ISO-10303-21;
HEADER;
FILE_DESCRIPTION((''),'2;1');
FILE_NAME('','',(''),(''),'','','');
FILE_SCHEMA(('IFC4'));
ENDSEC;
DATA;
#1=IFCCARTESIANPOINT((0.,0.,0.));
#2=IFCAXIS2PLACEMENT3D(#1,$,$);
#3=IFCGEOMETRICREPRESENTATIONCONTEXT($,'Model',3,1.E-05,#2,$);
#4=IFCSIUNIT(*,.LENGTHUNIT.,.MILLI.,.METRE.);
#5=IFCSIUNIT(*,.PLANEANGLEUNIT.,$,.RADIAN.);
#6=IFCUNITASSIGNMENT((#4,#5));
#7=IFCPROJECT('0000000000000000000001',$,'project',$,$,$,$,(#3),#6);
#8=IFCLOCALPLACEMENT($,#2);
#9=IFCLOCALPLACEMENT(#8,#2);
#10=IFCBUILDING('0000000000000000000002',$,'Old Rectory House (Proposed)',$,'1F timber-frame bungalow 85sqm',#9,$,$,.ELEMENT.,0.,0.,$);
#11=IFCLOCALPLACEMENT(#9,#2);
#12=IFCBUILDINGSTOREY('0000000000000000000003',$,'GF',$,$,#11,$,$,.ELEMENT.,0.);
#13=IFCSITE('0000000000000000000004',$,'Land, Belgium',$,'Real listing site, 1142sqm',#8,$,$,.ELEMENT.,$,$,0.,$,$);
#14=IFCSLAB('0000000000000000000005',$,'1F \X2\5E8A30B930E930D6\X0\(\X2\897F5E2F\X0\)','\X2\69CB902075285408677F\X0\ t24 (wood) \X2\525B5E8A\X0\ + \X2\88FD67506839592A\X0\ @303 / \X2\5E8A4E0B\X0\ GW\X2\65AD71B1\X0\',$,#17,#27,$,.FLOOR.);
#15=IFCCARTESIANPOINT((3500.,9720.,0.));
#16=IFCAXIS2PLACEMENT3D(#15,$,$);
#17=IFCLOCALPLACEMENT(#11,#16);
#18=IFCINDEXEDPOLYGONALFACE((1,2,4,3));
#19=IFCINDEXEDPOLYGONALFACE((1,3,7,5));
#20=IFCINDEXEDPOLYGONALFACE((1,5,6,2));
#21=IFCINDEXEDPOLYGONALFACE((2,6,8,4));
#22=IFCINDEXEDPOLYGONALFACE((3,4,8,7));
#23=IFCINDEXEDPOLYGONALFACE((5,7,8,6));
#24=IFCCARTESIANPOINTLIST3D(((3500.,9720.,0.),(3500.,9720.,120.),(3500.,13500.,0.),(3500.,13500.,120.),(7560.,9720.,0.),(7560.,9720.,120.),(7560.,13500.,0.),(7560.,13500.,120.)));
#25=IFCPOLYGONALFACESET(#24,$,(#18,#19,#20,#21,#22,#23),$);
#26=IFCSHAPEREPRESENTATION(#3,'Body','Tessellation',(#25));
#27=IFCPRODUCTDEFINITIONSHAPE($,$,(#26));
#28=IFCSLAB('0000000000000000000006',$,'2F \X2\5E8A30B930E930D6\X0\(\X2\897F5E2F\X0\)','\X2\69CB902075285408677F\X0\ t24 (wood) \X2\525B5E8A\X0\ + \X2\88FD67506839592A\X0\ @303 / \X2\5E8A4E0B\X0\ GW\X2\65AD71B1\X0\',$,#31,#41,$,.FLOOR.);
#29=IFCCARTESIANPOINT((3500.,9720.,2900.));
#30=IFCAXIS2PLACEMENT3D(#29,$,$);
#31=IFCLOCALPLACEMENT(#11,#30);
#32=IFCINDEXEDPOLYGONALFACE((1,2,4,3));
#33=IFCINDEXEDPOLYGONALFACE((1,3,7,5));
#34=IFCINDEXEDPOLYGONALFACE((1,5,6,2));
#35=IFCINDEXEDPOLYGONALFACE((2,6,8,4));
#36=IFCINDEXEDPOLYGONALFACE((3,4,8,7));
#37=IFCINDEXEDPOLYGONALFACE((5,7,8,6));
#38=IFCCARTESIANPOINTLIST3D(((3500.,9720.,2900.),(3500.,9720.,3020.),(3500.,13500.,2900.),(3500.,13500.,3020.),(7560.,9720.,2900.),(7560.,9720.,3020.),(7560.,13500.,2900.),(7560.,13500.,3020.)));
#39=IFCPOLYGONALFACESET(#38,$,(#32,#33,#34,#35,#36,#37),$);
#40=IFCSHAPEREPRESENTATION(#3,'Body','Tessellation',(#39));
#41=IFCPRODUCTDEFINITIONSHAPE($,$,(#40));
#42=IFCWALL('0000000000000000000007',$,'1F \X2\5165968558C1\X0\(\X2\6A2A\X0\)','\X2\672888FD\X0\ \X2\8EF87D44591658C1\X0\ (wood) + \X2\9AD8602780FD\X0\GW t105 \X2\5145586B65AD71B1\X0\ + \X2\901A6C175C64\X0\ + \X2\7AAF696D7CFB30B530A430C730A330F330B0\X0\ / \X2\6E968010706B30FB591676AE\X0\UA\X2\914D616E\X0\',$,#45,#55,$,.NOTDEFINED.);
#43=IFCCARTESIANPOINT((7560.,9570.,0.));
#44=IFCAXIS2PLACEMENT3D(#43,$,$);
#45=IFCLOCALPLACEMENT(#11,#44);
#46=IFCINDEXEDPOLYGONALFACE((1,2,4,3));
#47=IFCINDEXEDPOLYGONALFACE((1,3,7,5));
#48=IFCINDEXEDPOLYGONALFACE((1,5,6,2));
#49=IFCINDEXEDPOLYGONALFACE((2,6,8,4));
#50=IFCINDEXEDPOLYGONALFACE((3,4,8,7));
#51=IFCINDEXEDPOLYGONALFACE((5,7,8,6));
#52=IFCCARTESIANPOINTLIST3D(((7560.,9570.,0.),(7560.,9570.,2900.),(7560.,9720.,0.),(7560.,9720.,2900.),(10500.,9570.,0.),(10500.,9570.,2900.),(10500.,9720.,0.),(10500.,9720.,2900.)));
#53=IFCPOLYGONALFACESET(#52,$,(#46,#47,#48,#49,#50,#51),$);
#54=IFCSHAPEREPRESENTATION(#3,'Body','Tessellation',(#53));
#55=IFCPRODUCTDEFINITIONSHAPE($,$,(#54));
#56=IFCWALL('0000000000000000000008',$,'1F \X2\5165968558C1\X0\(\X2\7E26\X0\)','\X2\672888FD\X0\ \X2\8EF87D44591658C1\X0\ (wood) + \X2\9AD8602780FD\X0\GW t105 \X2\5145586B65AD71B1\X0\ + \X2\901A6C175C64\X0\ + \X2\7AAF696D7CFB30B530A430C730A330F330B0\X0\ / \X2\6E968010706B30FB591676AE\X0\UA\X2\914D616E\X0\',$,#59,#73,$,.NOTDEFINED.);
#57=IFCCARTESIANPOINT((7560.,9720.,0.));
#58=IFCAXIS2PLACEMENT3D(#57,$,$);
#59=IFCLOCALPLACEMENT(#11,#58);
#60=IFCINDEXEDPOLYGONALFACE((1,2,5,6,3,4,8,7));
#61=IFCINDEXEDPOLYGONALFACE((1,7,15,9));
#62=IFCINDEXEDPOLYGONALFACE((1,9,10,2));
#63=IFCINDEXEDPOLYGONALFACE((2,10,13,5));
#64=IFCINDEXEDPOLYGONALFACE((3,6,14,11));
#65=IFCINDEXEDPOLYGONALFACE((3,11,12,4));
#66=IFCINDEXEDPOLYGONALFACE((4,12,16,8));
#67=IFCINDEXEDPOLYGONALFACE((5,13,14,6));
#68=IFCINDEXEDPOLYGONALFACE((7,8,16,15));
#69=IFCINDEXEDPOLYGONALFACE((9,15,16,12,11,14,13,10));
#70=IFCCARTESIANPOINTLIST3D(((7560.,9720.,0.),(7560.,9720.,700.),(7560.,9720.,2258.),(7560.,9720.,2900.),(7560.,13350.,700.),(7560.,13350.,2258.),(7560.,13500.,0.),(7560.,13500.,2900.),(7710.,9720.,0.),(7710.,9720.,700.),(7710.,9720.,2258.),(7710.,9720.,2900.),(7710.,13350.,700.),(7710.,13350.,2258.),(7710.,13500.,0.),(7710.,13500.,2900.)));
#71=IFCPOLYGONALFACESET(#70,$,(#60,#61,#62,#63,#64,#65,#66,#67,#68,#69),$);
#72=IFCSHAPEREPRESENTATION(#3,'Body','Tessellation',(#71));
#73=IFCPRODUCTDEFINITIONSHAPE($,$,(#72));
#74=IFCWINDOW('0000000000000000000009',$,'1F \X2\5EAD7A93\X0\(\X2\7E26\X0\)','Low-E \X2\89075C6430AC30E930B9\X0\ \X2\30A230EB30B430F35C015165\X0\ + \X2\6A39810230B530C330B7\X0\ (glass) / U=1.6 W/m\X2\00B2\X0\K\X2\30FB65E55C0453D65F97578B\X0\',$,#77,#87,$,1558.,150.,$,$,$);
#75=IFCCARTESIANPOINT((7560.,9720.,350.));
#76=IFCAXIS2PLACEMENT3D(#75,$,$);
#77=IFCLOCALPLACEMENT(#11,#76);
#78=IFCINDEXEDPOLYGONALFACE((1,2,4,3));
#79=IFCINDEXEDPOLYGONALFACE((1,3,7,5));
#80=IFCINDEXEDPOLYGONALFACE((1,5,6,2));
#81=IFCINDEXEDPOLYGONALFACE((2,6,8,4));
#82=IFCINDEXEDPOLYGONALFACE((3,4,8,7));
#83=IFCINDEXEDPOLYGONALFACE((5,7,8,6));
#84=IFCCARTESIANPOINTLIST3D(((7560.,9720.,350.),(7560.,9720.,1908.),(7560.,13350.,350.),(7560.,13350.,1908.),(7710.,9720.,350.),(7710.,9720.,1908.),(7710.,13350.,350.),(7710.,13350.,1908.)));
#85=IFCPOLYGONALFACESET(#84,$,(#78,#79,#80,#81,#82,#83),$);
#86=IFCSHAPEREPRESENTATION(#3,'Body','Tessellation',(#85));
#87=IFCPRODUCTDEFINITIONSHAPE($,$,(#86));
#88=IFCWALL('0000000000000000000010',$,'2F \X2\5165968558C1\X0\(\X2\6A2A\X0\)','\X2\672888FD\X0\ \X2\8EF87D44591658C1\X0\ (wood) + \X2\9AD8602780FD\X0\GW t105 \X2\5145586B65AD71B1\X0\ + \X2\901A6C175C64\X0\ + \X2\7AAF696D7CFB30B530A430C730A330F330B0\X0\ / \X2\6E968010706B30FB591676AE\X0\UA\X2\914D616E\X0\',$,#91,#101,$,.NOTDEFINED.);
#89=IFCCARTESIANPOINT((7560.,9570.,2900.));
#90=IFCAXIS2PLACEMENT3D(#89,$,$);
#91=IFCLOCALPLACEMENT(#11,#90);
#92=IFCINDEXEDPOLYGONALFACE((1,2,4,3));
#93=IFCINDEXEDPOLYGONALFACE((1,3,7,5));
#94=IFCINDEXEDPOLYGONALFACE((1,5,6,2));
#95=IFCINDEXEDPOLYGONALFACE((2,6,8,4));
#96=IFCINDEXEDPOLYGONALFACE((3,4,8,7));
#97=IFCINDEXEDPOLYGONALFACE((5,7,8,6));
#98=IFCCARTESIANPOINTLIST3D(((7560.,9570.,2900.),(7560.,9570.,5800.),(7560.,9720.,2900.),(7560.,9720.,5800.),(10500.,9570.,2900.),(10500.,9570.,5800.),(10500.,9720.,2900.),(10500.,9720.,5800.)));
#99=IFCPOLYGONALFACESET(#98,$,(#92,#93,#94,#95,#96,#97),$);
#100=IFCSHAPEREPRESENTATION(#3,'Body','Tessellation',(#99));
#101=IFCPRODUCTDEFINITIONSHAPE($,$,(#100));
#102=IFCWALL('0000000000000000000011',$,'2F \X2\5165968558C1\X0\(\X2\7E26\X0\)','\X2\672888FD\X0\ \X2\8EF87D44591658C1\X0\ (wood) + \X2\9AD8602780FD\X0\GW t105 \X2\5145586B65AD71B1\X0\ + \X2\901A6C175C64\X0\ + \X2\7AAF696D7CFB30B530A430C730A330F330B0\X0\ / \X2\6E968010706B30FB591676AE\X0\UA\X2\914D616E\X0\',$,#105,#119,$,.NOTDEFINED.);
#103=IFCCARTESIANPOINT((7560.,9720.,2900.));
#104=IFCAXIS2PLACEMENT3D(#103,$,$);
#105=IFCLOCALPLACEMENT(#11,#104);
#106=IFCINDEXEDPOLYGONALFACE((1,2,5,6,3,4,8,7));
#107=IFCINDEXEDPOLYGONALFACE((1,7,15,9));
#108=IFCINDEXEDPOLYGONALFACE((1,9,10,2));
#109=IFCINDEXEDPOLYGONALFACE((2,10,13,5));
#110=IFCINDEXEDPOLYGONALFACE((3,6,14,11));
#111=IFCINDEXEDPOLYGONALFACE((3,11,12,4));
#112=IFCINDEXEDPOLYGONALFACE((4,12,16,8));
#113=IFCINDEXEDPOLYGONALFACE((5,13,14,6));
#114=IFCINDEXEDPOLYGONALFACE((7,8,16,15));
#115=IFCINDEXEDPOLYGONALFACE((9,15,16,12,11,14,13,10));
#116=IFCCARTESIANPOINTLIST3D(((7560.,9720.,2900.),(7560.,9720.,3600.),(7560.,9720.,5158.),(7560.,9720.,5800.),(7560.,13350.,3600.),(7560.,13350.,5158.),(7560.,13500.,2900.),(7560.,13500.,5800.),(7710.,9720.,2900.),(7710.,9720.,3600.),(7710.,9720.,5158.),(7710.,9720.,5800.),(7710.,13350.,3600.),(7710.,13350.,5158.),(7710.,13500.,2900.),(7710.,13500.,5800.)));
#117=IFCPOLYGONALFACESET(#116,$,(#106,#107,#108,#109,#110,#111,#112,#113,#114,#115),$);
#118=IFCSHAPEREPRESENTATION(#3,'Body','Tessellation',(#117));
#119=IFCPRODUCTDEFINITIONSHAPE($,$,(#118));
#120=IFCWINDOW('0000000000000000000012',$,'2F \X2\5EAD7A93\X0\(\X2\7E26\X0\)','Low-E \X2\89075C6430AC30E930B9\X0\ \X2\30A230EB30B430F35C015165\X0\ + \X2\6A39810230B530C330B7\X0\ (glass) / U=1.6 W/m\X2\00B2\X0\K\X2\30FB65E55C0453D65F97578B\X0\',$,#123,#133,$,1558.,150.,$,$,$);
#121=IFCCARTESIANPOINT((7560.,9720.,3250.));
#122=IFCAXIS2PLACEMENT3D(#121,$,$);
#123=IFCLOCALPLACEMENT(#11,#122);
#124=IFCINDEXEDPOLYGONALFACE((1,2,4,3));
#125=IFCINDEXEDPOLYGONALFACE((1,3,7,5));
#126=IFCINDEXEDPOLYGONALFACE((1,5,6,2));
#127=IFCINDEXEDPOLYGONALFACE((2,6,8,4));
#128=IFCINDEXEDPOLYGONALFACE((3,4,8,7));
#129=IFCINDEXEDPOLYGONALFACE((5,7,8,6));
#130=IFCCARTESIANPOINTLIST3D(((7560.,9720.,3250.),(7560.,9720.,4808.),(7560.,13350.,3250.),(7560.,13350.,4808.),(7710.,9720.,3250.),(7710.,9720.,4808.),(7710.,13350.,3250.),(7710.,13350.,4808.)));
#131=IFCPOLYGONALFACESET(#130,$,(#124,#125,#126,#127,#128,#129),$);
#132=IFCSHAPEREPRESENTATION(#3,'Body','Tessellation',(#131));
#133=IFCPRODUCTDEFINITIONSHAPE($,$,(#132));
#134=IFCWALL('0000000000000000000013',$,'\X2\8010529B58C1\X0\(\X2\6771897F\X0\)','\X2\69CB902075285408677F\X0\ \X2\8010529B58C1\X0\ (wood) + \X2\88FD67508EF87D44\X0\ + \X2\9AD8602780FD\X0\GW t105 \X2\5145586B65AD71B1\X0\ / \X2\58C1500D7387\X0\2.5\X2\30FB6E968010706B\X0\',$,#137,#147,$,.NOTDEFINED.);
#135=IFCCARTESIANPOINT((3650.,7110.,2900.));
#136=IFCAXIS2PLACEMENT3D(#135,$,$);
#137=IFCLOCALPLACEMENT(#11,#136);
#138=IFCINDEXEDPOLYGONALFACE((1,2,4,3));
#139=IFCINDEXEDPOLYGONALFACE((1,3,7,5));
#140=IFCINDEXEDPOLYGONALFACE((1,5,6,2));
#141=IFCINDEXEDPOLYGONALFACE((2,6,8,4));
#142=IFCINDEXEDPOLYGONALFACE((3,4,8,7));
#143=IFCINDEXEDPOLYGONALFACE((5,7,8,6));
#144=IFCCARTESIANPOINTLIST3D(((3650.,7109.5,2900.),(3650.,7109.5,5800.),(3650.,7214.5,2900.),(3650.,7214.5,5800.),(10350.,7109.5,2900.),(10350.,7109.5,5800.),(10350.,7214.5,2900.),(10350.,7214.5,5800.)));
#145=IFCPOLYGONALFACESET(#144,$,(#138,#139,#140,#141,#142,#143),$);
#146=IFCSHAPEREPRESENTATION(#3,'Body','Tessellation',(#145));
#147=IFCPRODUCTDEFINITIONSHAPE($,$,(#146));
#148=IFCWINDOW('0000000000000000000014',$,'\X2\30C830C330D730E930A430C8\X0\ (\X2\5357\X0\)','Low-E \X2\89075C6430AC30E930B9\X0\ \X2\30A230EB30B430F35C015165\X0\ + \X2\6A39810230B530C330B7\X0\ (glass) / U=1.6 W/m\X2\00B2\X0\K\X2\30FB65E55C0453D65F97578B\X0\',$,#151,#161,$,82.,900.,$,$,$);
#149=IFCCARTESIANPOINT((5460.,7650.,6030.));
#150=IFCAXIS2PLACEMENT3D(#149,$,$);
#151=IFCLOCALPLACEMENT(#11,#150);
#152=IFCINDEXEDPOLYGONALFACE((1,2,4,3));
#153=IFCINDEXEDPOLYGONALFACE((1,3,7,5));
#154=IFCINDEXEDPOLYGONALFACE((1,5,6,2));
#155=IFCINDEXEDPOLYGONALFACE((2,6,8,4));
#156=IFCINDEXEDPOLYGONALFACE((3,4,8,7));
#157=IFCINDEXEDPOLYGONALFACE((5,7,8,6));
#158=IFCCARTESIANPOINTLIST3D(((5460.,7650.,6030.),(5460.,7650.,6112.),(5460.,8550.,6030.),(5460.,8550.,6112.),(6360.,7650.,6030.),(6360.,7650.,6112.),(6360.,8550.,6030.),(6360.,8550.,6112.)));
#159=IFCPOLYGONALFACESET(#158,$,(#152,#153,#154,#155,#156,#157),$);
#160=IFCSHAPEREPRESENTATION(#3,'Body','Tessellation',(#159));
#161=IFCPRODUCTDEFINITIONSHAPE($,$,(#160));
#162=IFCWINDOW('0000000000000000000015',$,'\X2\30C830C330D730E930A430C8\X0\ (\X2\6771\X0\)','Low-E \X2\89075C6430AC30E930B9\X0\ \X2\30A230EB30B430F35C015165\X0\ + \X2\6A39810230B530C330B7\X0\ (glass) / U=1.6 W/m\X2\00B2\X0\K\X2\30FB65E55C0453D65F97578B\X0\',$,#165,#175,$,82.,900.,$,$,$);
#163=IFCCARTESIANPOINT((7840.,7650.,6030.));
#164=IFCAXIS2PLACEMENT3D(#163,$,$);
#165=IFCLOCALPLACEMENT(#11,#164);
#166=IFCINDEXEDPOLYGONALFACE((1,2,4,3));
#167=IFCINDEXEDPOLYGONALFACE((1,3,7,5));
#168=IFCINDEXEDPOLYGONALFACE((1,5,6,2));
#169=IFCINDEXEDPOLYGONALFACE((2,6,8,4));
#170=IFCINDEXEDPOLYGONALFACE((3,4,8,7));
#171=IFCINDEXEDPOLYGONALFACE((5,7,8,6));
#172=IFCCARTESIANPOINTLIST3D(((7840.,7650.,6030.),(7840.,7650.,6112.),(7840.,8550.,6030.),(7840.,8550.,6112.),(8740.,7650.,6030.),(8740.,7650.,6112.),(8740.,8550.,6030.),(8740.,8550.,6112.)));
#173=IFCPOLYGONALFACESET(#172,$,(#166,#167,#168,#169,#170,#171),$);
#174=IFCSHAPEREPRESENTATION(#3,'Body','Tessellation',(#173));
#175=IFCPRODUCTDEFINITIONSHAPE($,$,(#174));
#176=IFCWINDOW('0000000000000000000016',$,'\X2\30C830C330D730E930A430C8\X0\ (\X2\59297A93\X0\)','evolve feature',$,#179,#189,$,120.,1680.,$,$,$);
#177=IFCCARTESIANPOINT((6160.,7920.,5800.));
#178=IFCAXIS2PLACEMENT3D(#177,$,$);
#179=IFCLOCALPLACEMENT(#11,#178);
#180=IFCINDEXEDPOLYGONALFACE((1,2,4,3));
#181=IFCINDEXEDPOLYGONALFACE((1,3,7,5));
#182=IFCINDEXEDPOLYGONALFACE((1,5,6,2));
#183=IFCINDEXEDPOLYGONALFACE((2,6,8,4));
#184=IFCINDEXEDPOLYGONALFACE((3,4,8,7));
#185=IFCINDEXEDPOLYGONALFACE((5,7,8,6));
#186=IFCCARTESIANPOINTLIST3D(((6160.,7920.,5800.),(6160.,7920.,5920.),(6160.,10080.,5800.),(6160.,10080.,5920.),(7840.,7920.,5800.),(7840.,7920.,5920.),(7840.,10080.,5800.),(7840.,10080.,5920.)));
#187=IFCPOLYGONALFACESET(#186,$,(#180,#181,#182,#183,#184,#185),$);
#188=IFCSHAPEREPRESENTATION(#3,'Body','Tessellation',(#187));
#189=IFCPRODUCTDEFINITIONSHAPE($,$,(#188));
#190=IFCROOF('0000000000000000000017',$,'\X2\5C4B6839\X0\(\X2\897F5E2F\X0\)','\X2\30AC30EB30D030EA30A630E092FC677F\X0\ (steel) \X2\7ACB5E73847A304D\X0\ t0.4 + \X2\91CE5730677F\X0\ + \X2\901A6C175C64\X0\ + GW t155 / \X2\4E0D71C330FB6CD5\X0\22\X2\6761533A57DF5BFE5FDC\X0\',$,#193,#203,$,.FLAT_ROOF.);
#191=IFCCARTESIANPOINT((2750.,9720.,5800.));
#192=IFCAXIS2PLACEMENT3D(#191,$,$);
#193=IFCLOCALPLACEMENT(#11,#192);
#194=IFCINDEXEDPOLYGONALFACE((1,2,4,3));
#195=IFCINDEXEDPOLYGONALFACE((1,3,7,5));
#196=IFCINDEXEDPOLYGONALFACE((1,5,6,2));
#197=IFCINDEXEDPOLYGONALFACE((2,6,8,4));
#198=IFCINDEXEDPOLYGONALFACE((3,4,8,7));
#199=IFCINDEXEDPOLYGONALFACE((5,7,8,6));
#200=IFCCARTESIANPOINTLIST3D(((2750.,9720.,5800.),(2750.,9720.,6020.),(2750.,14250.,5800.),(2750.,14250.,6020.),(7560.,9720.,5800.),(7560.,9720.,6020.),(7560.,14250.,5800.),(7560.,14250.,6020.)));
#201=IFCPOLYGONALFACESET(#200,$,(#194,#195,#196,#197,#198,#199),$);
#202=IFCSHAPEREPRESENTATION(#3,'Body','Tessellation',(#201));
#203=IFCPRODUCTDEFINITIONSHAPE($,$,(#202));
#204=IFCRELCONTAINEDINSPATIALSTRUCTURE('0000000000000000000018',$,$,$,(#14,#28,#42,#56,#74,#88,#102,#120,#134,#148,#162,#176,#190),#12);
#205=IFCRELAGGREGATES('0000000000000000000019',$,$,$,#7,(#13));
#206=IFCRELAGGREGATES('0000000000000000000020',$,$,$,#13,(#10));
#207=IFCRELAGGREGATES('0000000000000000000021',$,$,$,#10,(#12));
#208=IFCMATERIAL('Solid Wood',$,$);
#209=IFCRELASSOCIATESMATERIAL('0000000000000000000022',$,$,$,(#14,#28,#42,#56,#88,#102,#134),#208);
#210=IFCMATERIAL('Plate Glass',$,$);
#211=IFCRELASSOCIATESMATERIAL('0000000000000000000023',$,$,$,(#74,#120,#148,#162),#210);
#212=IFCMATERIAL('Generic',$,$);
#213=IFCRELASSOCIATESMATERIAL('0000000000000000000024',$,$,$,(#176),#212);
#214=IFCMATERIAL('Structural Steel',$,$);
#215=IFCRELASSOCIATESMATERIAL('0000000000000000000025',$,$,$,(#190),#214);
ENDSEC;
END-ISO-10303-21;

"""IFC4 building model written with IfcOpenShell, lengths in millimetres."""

from ifc_helpers import new_model, si_unit, frame, frame_2d, origin, place, context, project, spatial, rectangle, extrude, material, element, fill, save


model = new_model("IFC4")

# Units and contexts
model_context = context("Model", 3, precision=1e-05, world=origin())
ifc_project = project(units=[si_unit("LENGTHUNIT", "METRE", prefix="MILLI"), si_unit("PLANEANGLEUNIT", "RADIAN")], contexts=[model_context])

# Site, building, storey
site_placement = place(None, origin())
site = spatial("IfcSite", under=ifc_project, at=site_placement, Name="Land, Belgium", ObjectType="Real listing site, 1142sqm", CompositionType="ELEMENT", RefElevation=0.0)
building_placement = place(site_placement, origin())
building = spatial("IfcBuilding", under=site, at=building_placement, Name="Old Rectory House (Proposed)", ObjectType="1F timber-frame bungalow 85sqm", CompositionType="ELEMENT", ElevationOfRefHeight=0.0, ElevationOfTerrain=0.0)
storey_placement = place(building_placement, origin())
storey = spatial("IfcBuildingStorey", under=building, at=storey_placement, Name="GF", CompositionType="ELEMENT", Elevation=0.0)

# Slabs
ifc_material_1 = material(Name="Solid Wood")
slab_1_placement = place(storey_placement, frame((3500.0, 9720.0, 0.0)))
element("IfcSlab", 1, at=slab_1_placement, inside=storey, material=ifc_material_1, Name="1F 床スラブ(西帯)", Description="構造用合板 t24 (wood) 剛床 + 製材根太 @303 / 床下 GW断熱", PredefinedType="FLOOR", context=model_context, shape_type="SweptSolid", body=[
    extrude(rectangle(XDim=4060.0, YDim=3780.0, at=frame_2d((2030.0, 1890.0))), frame((3500.0, 9720.0, 0.0)), (0.0, 0.0, 1.0), 120.0),
])
slab_2_placement = place(storey_placement, frame((3500.0, 9720.0, 2900.0)))
element("IfcSlab", 2, at=slab_2_placement, inside=storey, material=ifc_material_1, Name="2F 床スラブ(西帯)", Description="構造用合板 t24 (wood) 剛床 + 製材根太 @303 / 床下 GW断熱", PredefinedType="FLOOR", context=model_context, shape_type="SweptSolid", body=[
    extrude(rectangle(XDim=4060.0, YDim=3780.0, at=frame_2d((2030.0, 1890.0))), frame((3500.0, 9720.0, 2900.0)), (0.0, 0.0, 1.0), 120.0),
])

# Wall
wall_1_placement = place(storey_placement, frame((7560.0, 9570.0, 0.0)))
element("IfcWall", 3, at=wall_1_placement, inside=storey, material=ifc_material_1, Name="1F 入隅壁(横)", Description="木製 軸組外壁 (wood) + 高性能GW t105 充填断熱 + 通気層 + 窯業系サイディング / 準耐火・外皮UA配慮", PredefinedType="NOTDEFINED", context=model_context, shape_type="SweptSolid", body=[
    extrude(rectangle(XDim=2940.0, YDim=150.0, at=frame_2d((1470.0, 75.0))), frame((7560.0, 9570.0, 0.0)), (0.0, 0.0, 1.0), 2900.0),
])

# Wall, opening, window
wall_2_placement = place(storey_placement, frame((7560.0, 9720.0, 0.0)))
wall_2 = element("IfcWall", 4, at=wall_2_placement, inside=storey, material=ifc_material_1, Name="1F 入隅壁(縦)", Description="木製 軸組外壁 (wood) + 高性能GW t105 充填断熱 + 通気層 + 窯業系サイディング / 準耐火・外皮UA配慮", PredefinedType="NOTDEFINED", context=model_context, shape_type="SweptSolid", body=[
    extrude(rectangle(XDim=150.0, YDim=3780.0, at=frame_2d((75.0, 1890.0))), frame((7560.0, 9720.0, 0.0)), (0.0, 0.0, 1.0), 2900.0),
])
opening_1_placement = place(storey_placement, frame((7560.0, 9720.0, 350.0)))
opening_1 = element("IfcOpeningElement", 5, at=opening_1_placement, cuts=wall_2, PredefinedType="NOTDEFINED", context=model_context, shape_type="SweptSolid", body=[
    extrude(rectangle(XDim=150.0, YDim=3630.0, at=frame_2d((75.0, 1815.0))), frame((7560.0, 9720.0, 350.0)), (0.0, 0.0, 1.0), 1558.0),
])
ifc_material_2 = material(Name="Plate Glass")
window_1_placement = place(storey_placement, frame((7560.0, 9720.0, 350.0)))
window_1 = element("IfcWindow", 6, at=window_1_placement, inside=storey, material=ifc_material_2, Name="1F 庭窓(縦)", Description="Low-E 複層ガラス アルゴン封入 + 樹脂サッシ (glass) / U=1.6 W/m²K・日射取得型", OverallHeight=1558.0, OverallWidth=150.0, context=model_context, shape_type="SweptSolid", body=[
    extrude(rectangle(XDim=150.0, YDim=3630.0, at=frame_2d((75.0, 1815.0))), frame((7560.0, 9720.0, 350.0)), (0.0, 0.0, 1.0), 1558.0),
])
fill(opening_1, window_1)

# Wall
wall_3_placement = place(storey_placement, frame((7560.0, 9570.0, 2900.0)))
element("IfcWall", 7, at=wall_3_placement, inside=storey, material=ifc_material_1, Name="2F 入隅壁(横)", Description="木製 軸組外壁 (wood) + 高性能GW t105 充填断熱 + 通気層 + 窯業系サイディング / 準耐火・外皮UA配慮", PredefinedType="NOTDEFINED", context=model_context, shape_type="SweptSolid", body=[
    extrude(rectangle(XDim=2940.0, YDim=150.0, at=frame_2d((1470.0, 75.0))), frame((7560.0, 9570.0, 2900.0)), (0.0, 0.0, 1.0), 2900.0),
])

# Wall, opening, window
wall_4_placement = place(storey_placement, frame((7560.0, 9720.0, 2900.0)))
wall_4 = element("IfcWall", 8, at=wall_4_placement, inside=storey, material=ifc_material_1, Name="2F 入隅壁(縦)", Description="木製 軸組外壁 (wood) + 高性能GW t105 充填断熱 + 通気層 + 窯業系サイディング / 準耐火・外皮UA配慮", PredefinedType="NOTDEFINED", context=model_context, shape_type="SweptSolid", body=[
    extrude(rectangle(XDim=150.0, YDim=3780.0, at=frame_2d((75.0, 1890.0))), frame((7560.0, 9720.0, 2900.0)), (0.0, 0.0, 1.0), 2900.0),
])
opening_2_placement = place(storey_placement, frame((7560.0, 9720.0, 3250.0)))
opening_2 = element("IfcOpeningElement", 9, at=opening_2_placement, cuts=wall_4, PredefinedType="NOTDEFINED", context=model_context, shape_type="SweptSolid", body=[
    extrude(rectangle(XDim=150.0, YDim=3630.0, at=frame_2d((75.0, 1815.0))), frame((7560.0, 9720.0, 3250.0)), (0.0, 0.0, 1.0), 1558.0),
])
window_2_placement = place(storey_placement, frame((7560.0, 9720.0, 3250.0)))
window_2 = element("IfcWindow", 10, at=window_2_placement, inside=storey, material=ifc_material_2, Name="2F 庭窓(縦)", Description="Low-E 複層ガラス アルゴン封入 + 樹脂サッシ (glass) / U=1.6 W/m²K・日射取得型", OverallHeight=1558.0, OverallWidth=150.0, context=model_context, shape_type="SweptSolid", body=[
    extrude(rectangle(XDim=150.0, YDim=3630.0, at=frame_2d((75.0, 1815.0))), frame((7560.0, 9720.0, 3250.0)), (0.0, 0.0, 1.0), 1558.0),
])
fill(opening_2, window_2)

# Wall
wall_5_placement = place(storey_placement, frame((3650.0, 7110.0, 2900.0)))
element("IfcWall", 11, at=wall_5_placement, inside=storey, material=ifc_material_1, Name="耐力壁(東西)", Description="構造用合板 耐力壁 (wood) + 製材軸組 + 高性能GW t105 充填断熱 / 壁倍率2.5・準耐火", PredefinedType="NOTDEFINED", context=model_context, shape_type="SweptSolid", body=[
    extrude(rectangle(XDim=6700.0, YDim=105.0, at=frame_2d((3350.0, 52.0))), frame((3650.0, 7110.0, 2900.0)), (0.0, 0.0, 1.0), 2900.0),
])

# Windows
window_3_placement = place(storey_placement, frame((5460.0, 7650.0, 6030.0)))
element("IfcWindow", 12, at=window_3_placement, inside=storey, material=ifc_material_2, Name="トップライト (南)", Description="Low-E 複層ガラス アルゴン封入 + 樹脂サッシ (glass) / U=1.6 W/m²K・日射取得型", OverallHeight=82.0, OverallWidth=900.0, context=model_context, shape_type="SweptSolid", body=[
    extrude(rectangle(XDim=900.0, YDim=900.0, at=frame_2d((450.0, 450.0))), frame((5460.0, 7650.0, 6030.0)), (0.0, 0.0, 1.0), 82.0),
])
window_4_placement = place(storey_placement, frame((7840.0, 7650.0, 6030.0)))
element("IfcWindow", 13, at=window_4_placement, inside=storey, material=ifc_material_2, Name="トップライト (東)", Description="Low-E 複層ガラス アルゴン封入 + 樹脂サッシ (glass) / U=1.6 W/m²K・日射取得型", OverallHeight=82.0, OverallWidth=900.0, context=model_context, shape_type="SweptSolid", body=[
    extrude(rectangle(XDim=900.0, YDim=900.0, at=frame_2d((450.0, 450.0))), frame((7840.0, 7650.0, 6030.0)), (0.0, 0.0, 1.0), 82.0),
])
ifc_material_3 = material(Name="Generic")
window_5_placement = place(storey_placement, frame((6160.0, 7920.0, 5800.0)))
element("IfcWindow", 14, at=window_5_placement, inside=storey, material=ifc_material_3, Name="トップライト (天窓)", Description="evolve feature", OverallHeight=120.0, OverallWidth=1680.0, context=model_context, shape_type="SweptSolid", body=[
    extrude(rectangle(XDim=1680.0, YDim=2160.0, at=frame_2d((840.0, 1080.0))), frame((6160.0, 7920.0, 5800.0)), (0.0, 0.0, 1.0), 120.0),
])

# Roof
ifc_material_4 = material(Name="Structural Steel")
for number, where, name in (
    (15, (2750.0, 9720.0, 5800.0), "屋根(西帯)"),
):
    element("IfcRoof", number, at=place(storey_placement, frame(where)), inside=storey, material=ifc_material_4, Name=name, Description="ガルバリウム鋼板 (steel) 立平葺き t0.4 + 野地板 + 通気層 + GW t155 / 不燃・法22条区域対応", PredefinedType="FLAT_ROOF", context=model_context, shape_type="SweptSolid", body=[
        extrude(rectangle(XDim=4810.0, YDim=4530.0, at=frame_2d((2405.0, 2265.0))), frame((2750.0, 9720.0, 5800.0)), (0.0, 0.0, 1.0), 220.0),
    ])

save(model, "model.ifc")
